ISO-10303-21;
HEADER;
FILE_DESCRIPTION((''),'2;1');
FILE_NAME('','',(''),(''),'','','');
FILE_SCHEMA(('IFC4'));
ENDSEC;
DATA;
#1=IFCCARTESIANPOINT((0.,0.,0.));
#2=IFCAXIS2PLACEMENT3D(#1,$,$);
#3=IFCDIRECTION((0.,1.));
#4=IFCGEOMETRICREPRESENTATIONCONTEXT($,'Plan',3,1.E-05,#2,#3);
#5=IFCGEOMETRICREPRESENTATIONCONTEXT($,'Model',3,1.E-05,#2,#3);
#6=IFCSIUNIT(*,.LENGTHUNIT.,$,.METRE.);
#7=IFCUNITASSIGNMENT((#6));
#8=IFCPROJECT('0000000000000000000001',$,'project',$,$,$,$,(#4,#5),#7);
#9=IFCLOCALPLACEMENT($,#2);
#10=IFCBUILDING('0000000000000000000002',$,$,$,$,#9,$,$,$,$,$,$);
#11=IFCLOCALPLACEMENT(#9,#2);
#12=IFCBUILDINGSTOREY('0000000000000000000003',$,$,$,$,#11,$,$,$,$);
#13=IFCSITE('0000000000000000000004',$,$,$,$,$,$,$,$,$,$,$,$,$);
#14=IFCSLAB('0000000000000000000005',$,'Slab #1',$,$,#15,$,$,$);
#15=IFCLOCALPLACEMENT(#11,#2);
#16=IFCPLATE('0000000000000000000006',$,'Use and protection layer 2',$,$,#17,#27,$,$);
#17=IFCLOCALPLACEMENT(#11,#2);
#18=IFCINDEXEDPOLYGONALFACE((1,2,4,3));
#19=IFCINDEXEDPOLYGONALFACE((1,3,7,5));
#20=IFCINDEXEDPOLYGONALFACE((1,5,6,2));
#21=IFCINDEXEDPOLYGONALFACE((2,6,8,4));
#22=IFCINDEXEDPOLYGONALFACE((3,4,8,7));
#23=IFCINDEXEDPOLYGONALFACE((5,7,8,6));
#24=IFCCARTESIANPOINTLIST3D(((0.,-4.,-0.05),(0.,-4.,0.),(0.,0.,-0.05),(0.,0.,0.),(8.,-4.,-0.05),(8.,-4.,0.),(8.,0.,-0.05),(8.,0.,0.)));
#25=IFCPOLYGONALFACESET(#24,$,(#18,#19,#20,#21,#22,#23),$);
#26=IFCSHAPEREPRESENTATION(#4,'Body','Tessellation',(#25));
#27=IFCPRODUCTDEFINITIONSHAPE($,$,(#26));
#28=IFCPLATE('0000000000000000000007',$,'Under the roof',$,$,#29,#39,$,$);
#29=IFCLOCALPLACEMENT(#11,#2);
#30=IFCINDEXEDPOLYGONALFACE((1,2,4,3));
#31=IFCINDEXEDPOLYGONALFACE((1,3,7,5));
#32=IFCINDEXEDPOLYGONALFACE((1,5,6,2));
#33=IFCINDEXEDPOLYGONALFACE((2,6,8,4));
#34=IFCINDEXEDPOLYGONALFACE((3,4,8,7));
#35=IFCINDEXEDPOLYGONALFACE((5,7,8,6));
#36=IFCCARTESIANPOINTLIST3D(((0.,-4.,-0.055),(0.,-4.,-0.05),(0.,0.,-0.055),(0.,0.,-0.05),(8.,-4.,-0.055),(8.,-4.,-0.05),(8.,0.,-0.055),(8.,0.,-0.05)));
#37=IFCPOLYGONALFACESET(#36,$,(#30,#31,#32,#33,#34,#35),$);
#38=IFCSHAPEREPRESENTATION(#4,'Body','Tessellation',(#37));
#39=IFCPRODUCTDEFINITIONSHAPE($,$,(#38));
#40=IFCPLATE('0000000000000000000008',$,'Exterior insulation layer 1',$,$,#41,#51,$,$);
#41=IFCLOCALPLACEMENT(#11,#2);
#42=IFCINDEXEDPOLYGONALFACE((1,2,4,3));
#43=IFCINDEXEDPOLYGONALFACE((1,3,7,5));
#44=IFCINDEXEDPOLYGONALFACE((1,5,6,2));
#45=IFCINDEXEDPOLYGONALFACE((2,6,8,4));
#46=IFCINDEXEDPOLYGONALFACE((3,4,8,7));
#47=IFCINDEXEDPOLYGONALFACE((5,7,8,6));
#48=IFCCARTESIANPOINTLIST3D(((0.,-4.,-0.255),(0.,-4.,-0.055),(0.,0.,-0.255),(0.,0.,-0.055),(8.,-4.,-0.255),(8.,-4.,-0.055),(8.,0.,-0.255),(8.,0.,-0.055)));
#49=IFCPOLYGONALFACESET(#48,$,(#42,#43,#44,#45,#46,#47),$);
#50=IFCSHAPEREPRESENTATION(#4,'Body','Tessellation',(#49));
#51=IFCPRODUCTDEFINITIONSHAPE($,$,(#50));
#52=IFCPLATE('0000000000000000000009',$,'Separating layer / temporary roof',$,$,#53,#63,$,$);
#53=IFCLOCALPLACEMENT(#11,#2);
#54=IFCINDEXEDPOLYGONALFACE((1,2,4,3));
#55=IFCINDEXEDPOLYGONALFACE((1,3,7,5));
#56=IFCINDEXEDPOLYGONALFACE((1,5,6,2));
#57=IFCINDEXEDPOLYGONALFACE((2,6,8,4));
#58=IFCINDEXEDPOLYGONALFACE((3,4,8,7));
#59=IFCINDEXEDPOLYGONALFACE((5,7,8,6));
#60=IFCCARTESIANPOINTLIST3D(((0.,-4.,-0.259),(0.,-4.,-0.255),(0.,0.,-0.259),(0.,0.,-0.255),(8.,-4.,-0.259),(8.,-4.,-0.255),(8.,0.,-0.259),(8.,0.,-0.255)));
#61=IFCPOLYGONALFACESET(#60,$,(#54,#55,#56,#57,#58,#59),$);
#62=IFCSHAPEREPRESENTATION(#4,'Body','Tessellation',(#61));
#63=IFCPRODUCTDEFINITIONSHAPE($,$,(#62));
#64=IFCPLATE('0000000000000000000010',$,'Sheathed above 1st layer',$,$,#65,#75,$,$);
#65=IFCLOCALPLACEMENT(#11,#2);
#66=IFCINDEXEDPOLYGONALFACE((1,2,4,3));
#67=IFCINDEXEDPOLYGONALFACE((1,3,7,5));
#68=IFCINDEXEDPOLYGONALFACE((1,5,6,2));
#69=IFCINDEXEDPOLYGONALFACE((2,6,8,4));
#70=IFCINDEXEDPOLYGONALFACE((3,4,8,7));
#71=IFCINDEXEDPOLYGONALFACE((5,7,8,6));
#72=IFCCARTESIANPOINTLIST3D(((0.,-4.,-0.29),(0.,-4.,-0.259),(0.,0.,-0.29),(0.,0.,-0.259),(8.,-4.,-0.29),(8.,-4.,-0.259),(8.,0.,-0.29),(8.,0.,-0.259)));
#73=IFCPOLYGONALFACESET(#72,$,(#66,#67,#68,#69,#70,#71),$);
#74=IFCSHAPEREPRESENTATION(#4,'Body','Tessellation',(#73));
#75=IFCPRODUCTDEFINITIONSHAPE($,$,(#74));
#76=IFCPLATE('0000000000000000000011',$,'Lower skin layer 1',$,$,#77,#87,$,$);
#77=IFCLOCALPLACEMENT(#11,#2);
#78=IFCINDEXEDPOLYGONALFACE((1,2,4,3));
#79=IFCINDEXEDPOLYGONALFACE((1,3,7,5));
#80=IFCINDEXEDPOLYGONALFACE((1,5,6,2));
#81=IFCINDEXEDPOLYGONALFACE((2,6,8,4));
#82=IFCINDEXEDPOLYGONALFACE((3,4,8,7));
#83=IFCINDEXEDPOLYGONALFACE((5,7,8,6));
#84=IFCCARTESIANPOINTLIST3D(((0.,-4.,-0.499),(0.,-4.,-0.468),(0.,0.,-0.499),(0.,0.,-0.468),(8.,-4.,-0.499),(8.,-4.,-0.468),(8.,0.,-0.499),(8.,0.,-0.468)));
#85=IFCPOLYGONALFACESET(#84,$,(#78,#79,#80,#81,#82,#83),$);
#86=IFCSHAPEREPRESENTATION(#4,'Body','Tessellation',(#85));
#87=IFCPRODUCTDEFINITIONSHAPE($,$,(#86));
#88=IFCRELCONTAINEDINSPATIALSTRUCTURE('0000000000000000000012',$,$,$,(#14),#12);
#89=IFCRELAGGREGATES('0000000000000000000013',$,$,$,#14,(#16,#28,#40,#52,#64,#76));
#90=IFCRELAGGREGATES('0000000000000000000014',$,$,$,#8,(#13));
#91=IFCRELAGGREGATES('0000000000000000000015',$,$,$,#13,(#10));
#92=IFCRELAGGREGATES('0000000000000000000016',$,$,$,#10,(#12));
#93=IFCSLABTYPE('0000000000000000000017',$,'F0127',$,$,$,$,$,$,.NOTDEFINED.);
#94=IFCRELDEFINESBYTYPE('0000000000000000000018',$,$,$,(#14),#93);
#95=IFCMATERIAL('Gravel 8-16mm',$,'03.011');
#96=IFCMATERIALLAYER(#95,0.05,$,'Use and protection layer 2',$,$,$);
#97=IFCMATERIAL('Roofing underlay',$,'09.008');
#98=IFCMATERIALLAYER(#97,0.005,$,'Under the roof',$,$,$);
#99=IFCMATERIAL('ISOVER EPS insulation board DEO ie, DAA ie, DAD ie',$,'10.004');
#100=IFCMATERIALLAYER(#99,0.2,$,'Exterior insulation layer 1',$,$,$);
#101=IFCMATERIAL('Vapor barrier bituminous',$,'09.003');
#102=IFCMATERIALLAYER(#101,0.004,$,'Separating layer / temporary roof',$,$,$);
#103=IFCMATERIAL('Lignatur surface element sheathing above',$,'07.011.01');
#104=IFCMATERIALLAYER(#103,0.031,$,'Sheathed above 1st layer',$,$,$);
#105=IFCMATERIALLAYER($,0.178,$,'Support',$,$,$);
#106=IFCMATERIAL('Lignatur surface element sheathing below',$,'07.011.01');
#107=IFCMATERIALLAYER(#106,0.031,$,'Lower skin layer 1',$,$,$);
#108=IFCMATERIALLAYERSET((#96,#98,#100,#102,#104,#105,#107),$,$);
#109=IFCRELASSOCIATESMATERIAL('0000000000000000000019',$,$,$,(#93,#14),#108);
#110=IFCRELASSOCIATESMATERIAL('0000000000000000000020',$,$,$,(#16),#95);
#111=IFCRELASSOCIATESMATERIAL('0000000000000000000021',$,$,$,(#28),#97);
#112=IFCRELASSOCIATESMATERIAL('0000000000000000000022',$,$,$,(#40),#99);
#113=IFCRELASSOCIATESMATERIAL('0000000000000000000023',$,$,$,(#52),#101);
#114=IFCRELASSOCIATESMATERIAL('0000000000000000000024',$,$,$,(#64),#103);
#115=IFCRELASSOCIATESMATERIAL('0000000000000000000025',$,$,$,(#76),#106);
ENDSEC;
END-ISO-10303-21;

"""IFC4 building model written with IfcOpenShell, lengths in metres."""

from ifc_helpers import new_model, si_unit, direction, frame, frame_2d, origin, origin_with_axes, place, context, project, spatial, rectangle, extrude, material, layer, layer_set, type_object, element, aggregate, save


model = new_model("IFC4")

# Units and contexts
plan_context = context("Plan", 3, precision=1e-05, world=origin(), true_north=direction((0.0, 1.0)))
model_context = context("Model", 3, precision=1e-05, world=origin(), true_north=direction((0.0, 1.0)))
ifc_project = project(units=[si_unit("LENGTHUNIT", "METRE")], contexts=[plan_context, model_context])

# Site, building, storey
site = spatial("IfcSite", under=ifc_project)
building_placement = place(None, origin())
building = spatial("IfcBuilding", under=site, at=building_placement)
storey_placement = place(building_placement, origin())
storey = spatial("IfcBuildingStorey", under=building, at=storey_placement)

# Slab, plates
ifc_material_1 = material(Name="Gravel 8-16mm", Category="03.011")
ifc_layer_1 = layer(ifc_material_1, 0.05, Name="Use and protection layer 2")
ifc_material_2 = material(Name="Roofing underlay", Category="09.008")
ifc_layer_2 = layer(ifc_material_2, 0.005, Name="Under the roof")
ifc_material_3 = material(Name="ISOVER EPS insulation board DEO ie, DAA ie, DAD ie", Category="10.004")
ifc_layer_3 = layer(ifc_material_3, 0.2, Name="Exterior insulation layer 1")
ifc_material_4 = material(Name="Vapor barrier bituminous", Category="09.003")
ifc_layer_4 = layer(ifc_material_4, 0.004, Name="Separating layer / temporary roof")
ifc_material_5 = material(Name="Lignatur surface element sheathing above", Category="07.011.01")
ifc_layer_5 = layer(ifc_material_5, 0.031, Name="Sheathed above 1st layer")
ifc_layer_6 = layer(None, 0.178, Name="Support")
ifc_material_6 = material(Name="Lignatur surface element sheathing below", Category="07.011.01")
ifc_layer_7 = layer(ifc_material_6, 0.031, Name="Lower skin layer 1")
ifc_layer_set = layer_set([ifc_layer_1, ifc_layer_2, ifc_layer_3, ifc_layer_4, ifc_layer_5, ifc_layer_6, ifc_layer_7])
slab_type = type_object("IfcSlabType", Name="F0127", PredefinedType="NOTDEFINED", material=ifc_layer_set)
slab_placement = place(None, frame((0.0, 0.0, 0.0), z_axis=(0.0, 0.0, -1.0), x_axis=(1.0, 0.0, 0.0)))
slab = element("IfcSlab", 1, at=slab_placement, inside=storey, type_object=slab_type, material=ifc_layer_set, Name="Slab #1")
plate_1_placement = place(slab_placement, origin())
plate_1 = element("IfcPlate", 2, at=plate_1_placement, material=ifc_material_1, Name="Use and protection layer 2", context=plan_context, shape_type="SweptSolid", body=[
    extrude(rectangle(XDim=8.0, YDim=4.0, at=frame_2d((4.0, 2.0), x_axis=(1.0, 0.0))), origin_with_axes(), (0.0, 0.0, 1.0), 0.05),
])
plate_2_placement = place(slab_placement, origin())
plate_2 = element("IfcPlate", 3, at=plate_2_placement, material=ifc_material_2, Name="Under the roof", context=plan_context, shape_type="SweptSolid", body=[
    extrude(rectangle(XDim=8.0, YDim=4.0, at=frame_2d((4.0, 2.0), x_axis=(1.0, 0.0))), frame((0.0, 0.0, 0.05), z_axis=(0.0, 0.0, 1.0), x_axis=(1.0, 0.0, 0.0)), (0.0, 0.0, 1.0), 0.005),
])
plate_3_placement = place(slab_placement, origin())
plate_3 = element("IfcPlate", 4, at=plate_3_placement, material=ifc_material_3, Name="Exterior insulation layer 1", context=plan_context, shape_type="SweptSolid", body=[
    extrude(rectangle(XDim=8.0, YDim=4.0, at=frame_2d((4.0, 2.0), x_axis=(1.0, 0.0))), frame((0.0, 0.0, 0.055), z_axis=(0.0, 0.0, 1.0), x_axis=(1.0, 0.0, 0.0)), (0.0, 0.0, 1.0), 0.2),
])
plate_4_placement = place(slab_placement, origin())
plate_4 = element("IfcPlate", 5, at=plate_4_placement, material=ifc_material_4, Name="Separating layer / temporary roof", context=plan_context, shape_type="SweptSolid", body=[
    extrude(rectangle(XDim=8.0, YDim=4.0, at=frame_2d((4.0, 2.0), x_axis=(1.0, 0.0))), frame((0.0, 0.0, 0.255), z_axis=(0.0, 0.0, 1.0), x_axis=(1.0, 0.0, 0.0)), (0.0, 0.0, 1.0), 0.004),
])
plate_5_placement = place(slab_placement, origin())
plate_5 = element("IfcPlate", 6, at=plate_5_placement, material=ifc_material_5, Name="Sheathed above 1st layer", context=plan_context, shape_type="SweptSolid", body=[
    extrude(rectangle(XDim=8.0, YDim=4.0, at=frame_2d((4.0, 2.0), x_axis=(1.0, 0.0))), frame((0.0, 0.0, 0.259), z_axis=(0.0, 0.0, 1.0), x_axis=(1.0, 0.0, 0.0)), (0.0, 0.0, 1.0), 0.031),
])
plate_6_placement = place(slab_placement, origin())
plate_6 = element("IfcPlate", 7, at=plate_6_placement, material=ifc_material_6, Name="Lower skin layer 1", context=plan_context, shape_type="SweptSolid", body=[
    extrude(rectangle(XDim=8.0, YDim=4.0, at=frame_2d((4.0, 2.0), x_axis=(1.0, 0.0))), frame((0.0, 0.0, 0.468), z_axis=(0.0, 0.0, 1.0), x_axis=(1.0, 0.0, 0.0)), (0.0, 0.0, 1.0), 0.031),
])
aggregate(slab, [plate_1, plate_2, plate_3, plate_4, plate_5, plate_6])

save(model, "model.ifc")
